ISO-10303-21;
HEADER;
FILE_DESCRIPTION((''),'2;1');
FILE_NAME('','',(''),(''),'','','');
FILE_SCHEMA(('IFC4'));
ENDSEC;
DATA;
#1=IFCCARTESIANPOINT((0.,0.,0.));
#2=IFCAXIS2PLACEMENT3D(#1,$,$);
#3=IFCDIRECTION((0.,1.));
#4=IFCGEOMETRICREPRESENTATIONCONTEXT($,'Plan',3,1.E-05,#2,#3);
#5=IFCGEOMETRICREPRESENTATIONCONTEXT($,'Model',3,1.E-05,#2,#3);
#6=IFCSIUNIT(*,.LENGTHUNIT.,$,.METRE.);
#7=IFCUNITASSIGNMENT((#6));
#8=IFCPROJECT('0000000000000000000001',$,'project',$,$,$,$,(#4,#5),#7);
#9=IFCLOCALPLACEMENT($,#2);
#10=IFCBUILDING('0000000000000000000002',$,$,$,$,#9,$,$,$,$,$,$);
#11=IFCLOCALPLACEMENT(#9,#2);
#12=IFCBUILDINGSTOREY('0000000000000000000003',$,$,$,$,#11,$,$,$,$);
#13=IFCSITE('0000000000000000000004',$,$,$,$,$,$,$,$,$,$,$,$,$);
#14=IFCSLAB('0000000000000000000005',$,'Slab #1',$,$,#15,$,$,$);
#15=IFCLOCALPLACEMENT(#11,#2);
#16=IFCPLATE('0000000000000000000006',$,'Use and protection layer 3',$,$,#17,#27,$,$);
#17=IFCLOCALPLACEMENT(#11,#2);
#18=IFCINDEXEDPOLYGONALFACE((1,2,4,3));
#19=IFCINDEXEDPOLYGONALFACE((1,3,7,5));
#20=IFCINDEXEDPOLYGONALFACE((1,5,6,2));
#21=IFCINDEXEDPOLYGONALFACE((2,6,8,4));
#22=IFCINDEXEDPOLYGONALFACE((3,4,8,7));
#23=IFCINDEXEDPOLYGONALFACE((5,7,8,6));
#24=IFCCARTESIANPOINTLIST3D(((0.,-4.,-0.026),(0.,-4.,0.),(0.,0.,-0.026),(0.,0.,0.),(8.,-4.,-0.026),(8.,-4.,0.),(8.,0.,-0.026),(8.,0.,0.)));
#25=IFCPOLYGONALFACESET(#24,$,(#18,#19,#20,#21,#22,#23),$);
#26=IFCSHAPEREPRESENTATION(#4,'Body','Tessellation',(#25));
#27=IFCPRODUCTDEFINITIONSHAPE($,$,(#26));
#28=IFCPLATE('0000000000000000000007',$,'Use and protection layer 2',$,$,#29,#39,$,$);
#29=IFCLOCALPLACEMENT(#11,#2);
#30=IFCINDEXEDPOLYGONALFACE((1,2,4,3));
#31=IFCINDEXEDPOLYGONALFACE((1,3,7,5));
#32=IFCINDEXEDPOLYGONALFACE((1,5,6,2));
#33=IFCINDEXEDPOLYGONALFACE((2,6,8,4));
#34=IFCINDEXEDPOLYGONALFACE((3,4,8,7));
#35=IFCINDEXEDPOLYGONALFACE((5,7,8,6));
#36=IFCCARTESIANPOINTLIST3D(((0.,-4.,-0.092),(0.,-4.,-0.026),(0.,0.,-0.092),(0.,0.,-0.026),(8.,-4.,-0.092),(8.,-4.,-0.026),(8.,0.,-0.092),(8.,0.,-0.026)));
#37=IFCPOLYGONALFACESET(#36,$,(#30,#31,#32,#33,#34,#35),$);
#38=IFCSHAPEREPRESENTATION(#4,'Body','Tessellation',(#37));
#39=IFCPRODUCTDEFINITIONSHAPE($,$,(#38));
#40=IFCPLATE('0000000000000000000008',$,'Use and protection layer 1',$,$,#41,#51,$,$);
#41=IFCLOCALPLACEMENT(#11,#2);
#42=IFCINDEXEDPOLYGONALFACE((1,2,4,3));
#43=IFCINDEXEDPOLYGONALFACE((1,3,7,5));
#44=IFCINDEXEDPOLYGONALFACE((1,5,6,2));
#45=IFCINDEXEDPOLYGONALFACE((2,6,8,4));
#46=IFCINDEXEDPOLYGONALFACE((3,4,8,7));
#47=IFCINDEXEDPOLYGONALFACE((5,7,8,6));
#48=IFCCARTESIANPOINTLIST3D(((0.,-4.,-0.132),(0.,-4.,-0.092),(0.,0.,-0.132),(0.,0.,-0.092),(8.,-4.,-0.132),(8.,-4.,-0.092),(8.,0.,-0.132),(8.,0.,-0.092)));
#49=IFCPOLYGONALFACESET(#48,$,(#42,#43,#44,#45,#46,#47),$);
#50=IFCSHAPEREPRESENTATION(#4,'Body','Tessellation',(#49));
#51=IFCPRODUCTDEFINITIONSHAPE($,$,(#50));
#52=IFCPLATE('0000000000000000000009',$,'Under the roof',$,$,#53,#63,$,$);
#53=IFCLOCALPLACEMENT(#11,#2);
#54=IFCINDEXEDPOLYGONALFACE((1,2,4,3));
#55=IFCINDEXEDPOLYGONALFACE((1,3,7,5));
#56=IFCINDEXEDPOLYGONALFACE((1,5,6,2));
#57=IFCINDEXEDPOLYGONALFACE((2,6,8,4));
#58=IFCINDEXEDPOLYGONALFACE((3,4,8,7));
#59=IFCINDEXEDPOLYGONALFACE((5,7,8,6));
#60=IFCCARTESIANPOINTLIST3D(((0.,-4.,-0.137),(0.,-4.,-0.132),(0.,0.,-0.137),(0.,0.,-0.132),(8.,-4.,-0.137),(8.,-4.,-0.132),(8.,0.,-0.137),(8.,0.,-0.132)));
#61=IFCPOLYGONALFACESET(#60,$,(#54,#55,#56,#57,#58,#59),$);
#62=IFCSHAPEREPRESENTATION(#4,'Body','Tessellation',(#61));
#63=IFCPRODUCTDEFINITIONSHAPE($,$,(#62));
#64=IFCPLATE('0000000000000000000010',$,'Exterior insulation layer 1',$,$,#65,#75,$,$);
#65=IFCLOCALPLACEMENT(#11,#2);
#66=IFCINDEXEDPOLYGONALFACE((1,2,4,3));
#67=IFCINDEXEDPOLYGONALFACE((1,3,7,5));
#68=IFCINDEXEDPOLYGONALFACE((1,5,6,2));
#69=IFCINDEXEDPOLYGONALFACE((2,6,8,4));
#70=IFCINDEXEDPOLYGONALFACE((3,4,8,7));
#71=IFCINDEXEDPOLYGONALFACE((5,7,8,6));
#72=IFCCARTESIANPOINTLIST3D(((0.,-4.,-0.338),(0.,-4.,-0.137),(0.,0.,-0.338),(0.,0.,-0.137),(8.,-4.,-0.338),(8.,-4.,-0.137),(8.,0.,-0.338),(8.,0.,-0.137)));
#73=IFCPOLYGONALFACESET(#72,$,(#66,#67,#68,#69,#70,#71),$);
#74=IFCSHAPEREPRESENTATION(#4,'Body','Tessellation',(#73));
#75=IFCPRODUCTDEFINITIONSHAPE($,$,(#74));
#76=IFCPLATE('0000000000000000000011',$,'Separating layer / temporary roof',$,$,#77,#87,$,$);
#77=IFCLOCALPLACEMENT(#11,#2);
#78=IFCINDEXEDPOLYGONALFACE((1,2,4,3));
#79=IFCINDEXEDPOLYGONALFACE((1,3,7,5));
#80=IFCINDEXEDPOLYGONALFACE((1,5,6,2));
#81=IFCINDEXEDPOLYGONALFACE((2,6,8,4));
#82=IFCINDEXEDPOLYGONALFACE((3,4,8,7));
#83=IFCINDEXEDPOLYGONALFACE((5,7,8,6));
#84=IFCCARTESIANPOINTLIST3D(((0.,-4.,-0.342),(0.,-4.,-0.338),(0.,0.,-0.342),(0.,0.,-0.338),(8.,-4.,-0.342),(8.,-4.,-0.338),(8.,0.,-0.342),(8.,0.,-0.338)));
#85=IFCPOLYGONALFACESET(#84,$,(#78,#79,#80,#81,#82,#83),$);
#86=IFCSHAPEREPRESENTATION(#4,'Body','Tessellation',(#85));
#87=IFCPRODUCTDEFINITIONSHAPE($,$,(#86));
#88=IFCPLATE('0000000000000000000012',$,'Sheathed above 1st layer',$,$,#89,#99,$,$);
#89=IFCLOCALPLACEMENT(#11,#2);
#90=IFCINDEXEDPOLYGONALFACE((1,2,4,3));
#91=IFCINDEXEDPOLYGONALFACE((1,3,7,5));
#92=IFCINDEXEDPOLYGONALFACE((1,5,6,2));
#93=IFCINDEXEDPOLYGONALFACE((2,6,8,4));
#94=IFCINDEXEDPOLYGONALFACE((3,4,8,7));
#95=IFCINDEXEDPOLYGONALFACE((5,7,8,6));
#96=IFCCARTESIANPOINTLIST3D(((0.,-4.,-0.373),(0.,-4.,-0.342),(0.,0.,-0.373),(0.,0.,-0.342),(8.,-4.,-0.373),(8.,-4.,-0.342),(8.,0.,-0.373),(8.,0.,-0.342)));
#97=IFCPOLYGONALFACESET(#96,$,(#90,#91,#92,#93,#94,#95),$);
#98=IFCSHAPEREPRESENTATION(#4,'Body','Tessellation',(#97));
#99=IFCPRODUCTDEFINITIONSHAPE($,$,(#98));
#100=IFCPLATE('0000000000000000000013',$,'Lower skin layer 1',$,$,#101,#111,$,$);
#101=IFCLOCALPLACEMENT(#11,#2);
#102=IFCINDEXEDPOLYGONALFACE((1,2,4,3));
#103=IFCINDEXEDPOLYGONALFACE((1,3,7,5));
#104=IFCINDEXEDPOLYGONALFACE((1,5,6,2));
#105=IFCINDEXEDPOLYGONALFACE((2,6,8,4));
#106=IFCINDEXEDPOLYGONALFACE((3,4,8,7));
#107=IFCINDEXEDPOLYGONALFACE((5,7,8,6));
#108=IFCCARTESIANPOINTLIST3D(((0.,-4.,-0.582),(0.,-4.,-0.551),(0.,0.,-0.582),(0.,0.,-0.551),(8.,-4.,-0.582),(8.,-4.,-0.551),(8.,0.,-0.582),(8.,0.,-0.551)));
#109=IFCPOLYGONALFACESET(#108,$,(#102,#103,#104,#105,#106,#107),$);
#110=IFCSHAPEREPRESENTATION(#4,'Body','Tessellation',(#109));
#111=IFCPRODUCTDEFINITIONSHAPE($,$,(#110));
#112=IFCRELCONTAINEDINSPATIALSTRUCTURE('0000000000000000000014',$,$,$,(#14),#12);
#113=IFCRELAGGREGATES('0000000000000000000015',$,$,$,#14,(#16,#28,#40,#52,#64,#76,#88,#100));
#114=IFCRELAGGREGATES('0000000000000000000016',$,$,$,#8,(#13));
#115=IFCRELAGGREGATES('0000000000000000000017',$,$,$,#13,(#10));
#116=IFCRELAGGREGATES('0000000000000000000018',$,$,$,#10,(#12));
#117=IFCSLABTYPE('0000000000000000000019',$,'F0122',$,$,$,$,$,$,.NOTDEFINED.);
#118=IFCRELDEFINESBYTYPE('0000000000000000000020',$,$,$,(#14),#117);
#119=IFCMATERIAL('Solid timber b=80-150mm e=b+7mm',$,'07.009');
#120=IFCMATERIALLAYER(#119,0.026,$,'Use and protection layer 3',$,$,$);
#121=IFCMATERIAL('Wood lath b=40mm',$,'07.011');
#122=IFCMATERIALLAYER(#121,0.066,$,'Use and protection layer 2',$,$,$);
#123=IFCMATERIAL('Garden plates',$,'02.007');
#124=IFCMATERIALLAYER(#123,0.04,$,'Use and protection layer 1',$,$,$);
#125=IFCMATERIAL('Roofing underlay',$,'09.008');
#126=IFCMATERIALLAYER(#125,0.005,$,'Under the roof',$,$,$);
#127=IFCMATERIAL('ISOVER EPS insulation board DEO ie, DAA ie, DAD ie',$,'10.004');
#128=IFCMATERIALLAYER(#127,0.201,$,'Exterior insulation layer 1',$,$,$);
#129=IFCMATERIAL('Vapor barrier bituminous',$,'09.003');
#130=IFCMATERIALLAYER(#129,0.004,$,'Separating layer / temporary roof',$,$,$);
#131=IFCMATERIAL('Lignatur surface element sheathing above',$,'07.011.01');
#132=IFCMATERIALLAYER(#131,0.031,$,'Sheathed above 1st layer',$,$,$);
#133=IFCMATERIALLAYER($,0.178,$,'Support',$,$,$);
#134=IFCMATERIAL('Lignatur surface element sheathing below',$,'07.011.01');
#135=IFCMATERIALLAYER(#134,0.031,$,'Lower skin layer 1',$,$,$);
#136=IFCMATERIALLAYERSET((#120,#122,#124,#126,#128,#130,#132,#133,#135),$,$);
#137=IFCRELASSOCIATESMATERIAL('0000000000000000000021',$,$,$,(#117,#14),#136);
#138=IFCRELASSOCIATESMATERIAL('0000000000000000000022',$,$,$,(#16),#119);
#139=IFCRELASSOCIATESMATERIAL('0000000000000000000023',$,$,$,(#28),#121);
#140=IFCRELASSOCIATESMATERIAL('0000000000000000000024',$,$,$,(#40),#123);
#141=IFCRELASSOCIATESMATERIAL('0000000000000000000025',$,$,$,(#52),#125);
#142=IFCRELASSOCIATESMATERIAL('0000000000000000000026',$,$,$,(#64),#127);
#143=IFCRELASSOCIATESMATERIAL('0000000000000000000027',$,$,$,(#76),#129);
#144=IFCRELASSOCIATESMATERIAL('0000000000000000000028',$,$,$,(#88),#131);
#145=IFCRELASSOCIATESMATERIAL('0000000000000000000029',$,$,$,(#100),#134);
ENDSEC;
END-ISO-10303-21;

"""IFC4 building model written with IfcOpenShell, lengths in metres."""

from ifc_helpers import new_model, si_unit, direction, frame, frame_2d, origin, origin_with_axes, place, context, project, spatial, rectangle, extrude, material, layer, layer_set, type_object, element, aggregate, save


model = new_model("IFC4")

# Units and contexts
plan_context = context("Plan", 3, precision=1e-05, world=origin(), true_north=direction((0.0, 1.0)))
model_context = context("Model", 3, precision=1e-05, world=origin(), true_north=direction((0.0, 1.0)))
ifc_project = project(units=[si_unit("LENGTHUNIT", "METRE")], contexts=[plan_context, model_context])

# Site, building, storey
site = spatial("IfcSite", under=ifc_project)
building_placement = place(None, origin())
building = spatial("IfcBuilding", under=site, at=building_placement)
storey_placement = place(building_placement, origin())
storey = spatial("IfcBuildingStorey", under=building, at=storey_placement)

# Slab, plates
ifc_material_1 = material(Name="Solid timber b=80-150mm e=b+7mm", Category="07.009")
ifc_layer_1 = layer(ifc_material_1, 0.026, Name="Use and protection layer 3")
ifc_material_2 = material(Name="Wood lath b=40mm", Category="07.011")
ifc_layer_2 = layer(ifc_material_2, 0.066, Name="Use and protection layer 2")
ifc_material_3 = material(Name="Garden plates", Category="02.007")
ifc_layer_3 = layer(ifc_material_3, 0.04, Name="Use and protection layer 1")
ifc_material_4 = material(Name="Roofing underlay", Category="09.008")
ifc_layer_4 = layer(ifc_material_4, 0.005, Name="Under the roof")
ifc_material_5 = material(Name="ISOVER EPS insulation board DEO ie, DAA ie, DAD ie", Category="10.004")
ifc_layer_5 = layer(ifc_material_5, 0.201, Name="Exterior insulation layer 1")
ifc_material_6 = material(Name="Vapor barrier bituminous", Category="09.003")
ifc_layer_6 = layer(ifc_material_6, 0.004, Name="Separating layer / temporary roof")
ifc_material_7 = material(Name="Lignatur surface element sheathing above", Category="07.011.01")
ifc_layer_7 = layer(ifc_material_7, 0.031, Name="Sheathed above 1st layer")
ifc_layer_8 = layer(None, 0.178, Name="Support")
ifc_material_8 = material(Name="Lignatur surface element sheathing below", Category="07.011.01")
ifc_layer_9 = layer(ifc_material_8, 0.031, Name="Lower skin layer 1")
ifc_layer_set = layer_set([ifc_layer_1, ifc_layer_2, ifc_layer_3, ifc_layer_4, ifc_layer_5, ifc_layer_6, ifc_layer_7, ifc_layer_8, ifc_layer_9])
slab_type = type_object("IfcSlabType", Name="F0122", PredefinedType="NOTDEFINED", material=ifc_layer_set)
slab_placement = place(None, frame((0.0, 0.0, 0.0), z_axis=(0.0, 0.0, -1.0), x_axis=(1.0, 0.0, 0.0)))
slab = element("IfcSlab", 1, at=slab_placement, inside=storey, type_object=slab_type, material=ifc_layer_set, Name="Slab #1")
plate_1_placement = place(slab_placement, origin())
plate_1 = element("IfcPlate", 2, at=plate_1_placement, material=ifc_material_1, Name="Use and protection layer 3", context=plan_context, shape_type="SweptSolid", body=[
    extrude(rectangle(XDim=8.0, YDim=4.0, at=frame_2d((4.0, 2.0), x_axis=(1.0, 0.0))), origin_with_axes(), (0.0, 0.0, 1.0), 0.026),
])
plate_2_placement = place(slab_placement, origin())
plate_2 = element("IfcPlate", 3, at=plate_2_placement, material=ifc_material_2, Name="Use and protection layer 2", context=plan_context, shape_type="SweptSolid", body=[
    extrude(rectangle(XDim=8.0, YDim=4.0, at=frame_2d((4.0, 2.0), x_axis=(1.0, 0.0))), frame((0.0, 0.0, 0.026), z_axis=(0.0, 0.0, 1.0), x_axis=(1.0, 0.0, 0.0)), (0.0, 0.0, 1.0), 0.066),
])
plate_3_placement = place(slab_placement, origin())
plate_3 = element("IfcPlate", 4, at=plate_3_placement, material=ifc_material_3, Name="Use and protection layer 1", context=plan_context, shape_type="SweptSolid", body=[
    extrude(rectangle(XDim=8.0, YDim=4.0, at=frame_2d((4.0, 2.0), x_axis=(1.0, 0.0))), frame((0.0, 0.0, 0.092), z_axis=(0.0, 0.0, 1.0), x_axis=(1.0, 0.0, 0.0)), (0.0, 0.0, 1.0), 0.04),
])
plate_4_placement = place(slab_placement, origin())
plate_4 = element("IfcPlate", 5, at=plate_4_placement, material=ifc_material_4, Name="Under the roof", context=plan_context, shape_type="SweptSolid", body=[
    extrude(rectangle(XDim=8.0, YDim=4.0, at=frame_2d((4.0, 2.0), x_axis=(1.0, 0.0))), frame((0.0, 0.0, 0.132), z_axis=(0.0, 0.0, 1.0), x_axis=(1.0, 0.0, 0.0)), (0.0, 0.0, 1.0), 0.005),
])
plate_5_placement = place(slab_placement, origin())
plate_5 = element("IfcPlate", 6, at=plate_5_placement, material=ifc_material_5, Name="Exterior insulation layer 1", context=plan_context, shape_type="SweptSolid", body=[
    extrude(rectangle(XDim=8.0, YDim=4.0, at=frame_2d((4.0, 2.0), x_axis=(1.0, 0.0))), frame((0.0, 0.0, 0.137), z_axis=(0.0, 0.0, 1.0), x_axis=(1.0, 0.0, 0.0)), (0.0, 0.0, 1.0), 0.201),
])
plate_6_placement = place(slab_placement, origin())
plate_6 = element("IfcPlate", 7, at=plate_6_placement, material=ifc_material_6, Name="Separating layer / temporary roof", context=plan_context, shape_type="SweptSolid", body=[
    extrude(rectangle(XDim=8.0, YDim=4.0, at=frame_2d((4.0, 2.0), x_axis=(1.0, 0.0))), frame((0.0, 0.0, 0.338), z_axis=(0.0, 0.0, 1.0), x_axis=(1.0, 0.0, 0.0)), (0.0, 0.0, 1.0), 0.004),
])
plate_7_placement = place(slab_placement, origin())
plate_7 = element("IfcPlate", 8, at=plate_7_placement, material=ifc_material_7, Name="Sheathed above 1st layer", context=plan_context, shape_type="SweptSolid", body=[
    extrude(rectangle(XDim=8.0, YDim=4.0, at=frame_2d((4.0, 2.0), x_axis=(1.0, 0.0))), frame((0.0, 0.0, 0.342), z_axis=(0.0, 0.0, 1.0), x_axis=(1.0, 0.0, 0.0)), (0.0, 0.0, 1.0), 0.031),
])
plate_8_placement = place(slab_placement, origin())
plate_8 = element("IfcPlate", 9, at=plate_8_placement, material=ifc_material_8, Name="Lower skin layer 1", context=plan_context, shape_type="SweptSolid", body=[
    extrude(rectangle(XDim=8.0, YDim=4.0, at=frame_2d((4.0, 2.0), x_axis=(1.0, 0.0))), frame((0.0, 0.0, 0.551), z_axis=(0.0, 0.0, 1.0), x_axis=(1.0, 0.0, 0.0)), (0.0, 0.0, 1.0), 0.031),
])
aggregate(slab, [plate_1, plate_2, plate_3, plate_4, plate_5, plate_6, plate_7, plate_8])

save(model, "model.ifc")
